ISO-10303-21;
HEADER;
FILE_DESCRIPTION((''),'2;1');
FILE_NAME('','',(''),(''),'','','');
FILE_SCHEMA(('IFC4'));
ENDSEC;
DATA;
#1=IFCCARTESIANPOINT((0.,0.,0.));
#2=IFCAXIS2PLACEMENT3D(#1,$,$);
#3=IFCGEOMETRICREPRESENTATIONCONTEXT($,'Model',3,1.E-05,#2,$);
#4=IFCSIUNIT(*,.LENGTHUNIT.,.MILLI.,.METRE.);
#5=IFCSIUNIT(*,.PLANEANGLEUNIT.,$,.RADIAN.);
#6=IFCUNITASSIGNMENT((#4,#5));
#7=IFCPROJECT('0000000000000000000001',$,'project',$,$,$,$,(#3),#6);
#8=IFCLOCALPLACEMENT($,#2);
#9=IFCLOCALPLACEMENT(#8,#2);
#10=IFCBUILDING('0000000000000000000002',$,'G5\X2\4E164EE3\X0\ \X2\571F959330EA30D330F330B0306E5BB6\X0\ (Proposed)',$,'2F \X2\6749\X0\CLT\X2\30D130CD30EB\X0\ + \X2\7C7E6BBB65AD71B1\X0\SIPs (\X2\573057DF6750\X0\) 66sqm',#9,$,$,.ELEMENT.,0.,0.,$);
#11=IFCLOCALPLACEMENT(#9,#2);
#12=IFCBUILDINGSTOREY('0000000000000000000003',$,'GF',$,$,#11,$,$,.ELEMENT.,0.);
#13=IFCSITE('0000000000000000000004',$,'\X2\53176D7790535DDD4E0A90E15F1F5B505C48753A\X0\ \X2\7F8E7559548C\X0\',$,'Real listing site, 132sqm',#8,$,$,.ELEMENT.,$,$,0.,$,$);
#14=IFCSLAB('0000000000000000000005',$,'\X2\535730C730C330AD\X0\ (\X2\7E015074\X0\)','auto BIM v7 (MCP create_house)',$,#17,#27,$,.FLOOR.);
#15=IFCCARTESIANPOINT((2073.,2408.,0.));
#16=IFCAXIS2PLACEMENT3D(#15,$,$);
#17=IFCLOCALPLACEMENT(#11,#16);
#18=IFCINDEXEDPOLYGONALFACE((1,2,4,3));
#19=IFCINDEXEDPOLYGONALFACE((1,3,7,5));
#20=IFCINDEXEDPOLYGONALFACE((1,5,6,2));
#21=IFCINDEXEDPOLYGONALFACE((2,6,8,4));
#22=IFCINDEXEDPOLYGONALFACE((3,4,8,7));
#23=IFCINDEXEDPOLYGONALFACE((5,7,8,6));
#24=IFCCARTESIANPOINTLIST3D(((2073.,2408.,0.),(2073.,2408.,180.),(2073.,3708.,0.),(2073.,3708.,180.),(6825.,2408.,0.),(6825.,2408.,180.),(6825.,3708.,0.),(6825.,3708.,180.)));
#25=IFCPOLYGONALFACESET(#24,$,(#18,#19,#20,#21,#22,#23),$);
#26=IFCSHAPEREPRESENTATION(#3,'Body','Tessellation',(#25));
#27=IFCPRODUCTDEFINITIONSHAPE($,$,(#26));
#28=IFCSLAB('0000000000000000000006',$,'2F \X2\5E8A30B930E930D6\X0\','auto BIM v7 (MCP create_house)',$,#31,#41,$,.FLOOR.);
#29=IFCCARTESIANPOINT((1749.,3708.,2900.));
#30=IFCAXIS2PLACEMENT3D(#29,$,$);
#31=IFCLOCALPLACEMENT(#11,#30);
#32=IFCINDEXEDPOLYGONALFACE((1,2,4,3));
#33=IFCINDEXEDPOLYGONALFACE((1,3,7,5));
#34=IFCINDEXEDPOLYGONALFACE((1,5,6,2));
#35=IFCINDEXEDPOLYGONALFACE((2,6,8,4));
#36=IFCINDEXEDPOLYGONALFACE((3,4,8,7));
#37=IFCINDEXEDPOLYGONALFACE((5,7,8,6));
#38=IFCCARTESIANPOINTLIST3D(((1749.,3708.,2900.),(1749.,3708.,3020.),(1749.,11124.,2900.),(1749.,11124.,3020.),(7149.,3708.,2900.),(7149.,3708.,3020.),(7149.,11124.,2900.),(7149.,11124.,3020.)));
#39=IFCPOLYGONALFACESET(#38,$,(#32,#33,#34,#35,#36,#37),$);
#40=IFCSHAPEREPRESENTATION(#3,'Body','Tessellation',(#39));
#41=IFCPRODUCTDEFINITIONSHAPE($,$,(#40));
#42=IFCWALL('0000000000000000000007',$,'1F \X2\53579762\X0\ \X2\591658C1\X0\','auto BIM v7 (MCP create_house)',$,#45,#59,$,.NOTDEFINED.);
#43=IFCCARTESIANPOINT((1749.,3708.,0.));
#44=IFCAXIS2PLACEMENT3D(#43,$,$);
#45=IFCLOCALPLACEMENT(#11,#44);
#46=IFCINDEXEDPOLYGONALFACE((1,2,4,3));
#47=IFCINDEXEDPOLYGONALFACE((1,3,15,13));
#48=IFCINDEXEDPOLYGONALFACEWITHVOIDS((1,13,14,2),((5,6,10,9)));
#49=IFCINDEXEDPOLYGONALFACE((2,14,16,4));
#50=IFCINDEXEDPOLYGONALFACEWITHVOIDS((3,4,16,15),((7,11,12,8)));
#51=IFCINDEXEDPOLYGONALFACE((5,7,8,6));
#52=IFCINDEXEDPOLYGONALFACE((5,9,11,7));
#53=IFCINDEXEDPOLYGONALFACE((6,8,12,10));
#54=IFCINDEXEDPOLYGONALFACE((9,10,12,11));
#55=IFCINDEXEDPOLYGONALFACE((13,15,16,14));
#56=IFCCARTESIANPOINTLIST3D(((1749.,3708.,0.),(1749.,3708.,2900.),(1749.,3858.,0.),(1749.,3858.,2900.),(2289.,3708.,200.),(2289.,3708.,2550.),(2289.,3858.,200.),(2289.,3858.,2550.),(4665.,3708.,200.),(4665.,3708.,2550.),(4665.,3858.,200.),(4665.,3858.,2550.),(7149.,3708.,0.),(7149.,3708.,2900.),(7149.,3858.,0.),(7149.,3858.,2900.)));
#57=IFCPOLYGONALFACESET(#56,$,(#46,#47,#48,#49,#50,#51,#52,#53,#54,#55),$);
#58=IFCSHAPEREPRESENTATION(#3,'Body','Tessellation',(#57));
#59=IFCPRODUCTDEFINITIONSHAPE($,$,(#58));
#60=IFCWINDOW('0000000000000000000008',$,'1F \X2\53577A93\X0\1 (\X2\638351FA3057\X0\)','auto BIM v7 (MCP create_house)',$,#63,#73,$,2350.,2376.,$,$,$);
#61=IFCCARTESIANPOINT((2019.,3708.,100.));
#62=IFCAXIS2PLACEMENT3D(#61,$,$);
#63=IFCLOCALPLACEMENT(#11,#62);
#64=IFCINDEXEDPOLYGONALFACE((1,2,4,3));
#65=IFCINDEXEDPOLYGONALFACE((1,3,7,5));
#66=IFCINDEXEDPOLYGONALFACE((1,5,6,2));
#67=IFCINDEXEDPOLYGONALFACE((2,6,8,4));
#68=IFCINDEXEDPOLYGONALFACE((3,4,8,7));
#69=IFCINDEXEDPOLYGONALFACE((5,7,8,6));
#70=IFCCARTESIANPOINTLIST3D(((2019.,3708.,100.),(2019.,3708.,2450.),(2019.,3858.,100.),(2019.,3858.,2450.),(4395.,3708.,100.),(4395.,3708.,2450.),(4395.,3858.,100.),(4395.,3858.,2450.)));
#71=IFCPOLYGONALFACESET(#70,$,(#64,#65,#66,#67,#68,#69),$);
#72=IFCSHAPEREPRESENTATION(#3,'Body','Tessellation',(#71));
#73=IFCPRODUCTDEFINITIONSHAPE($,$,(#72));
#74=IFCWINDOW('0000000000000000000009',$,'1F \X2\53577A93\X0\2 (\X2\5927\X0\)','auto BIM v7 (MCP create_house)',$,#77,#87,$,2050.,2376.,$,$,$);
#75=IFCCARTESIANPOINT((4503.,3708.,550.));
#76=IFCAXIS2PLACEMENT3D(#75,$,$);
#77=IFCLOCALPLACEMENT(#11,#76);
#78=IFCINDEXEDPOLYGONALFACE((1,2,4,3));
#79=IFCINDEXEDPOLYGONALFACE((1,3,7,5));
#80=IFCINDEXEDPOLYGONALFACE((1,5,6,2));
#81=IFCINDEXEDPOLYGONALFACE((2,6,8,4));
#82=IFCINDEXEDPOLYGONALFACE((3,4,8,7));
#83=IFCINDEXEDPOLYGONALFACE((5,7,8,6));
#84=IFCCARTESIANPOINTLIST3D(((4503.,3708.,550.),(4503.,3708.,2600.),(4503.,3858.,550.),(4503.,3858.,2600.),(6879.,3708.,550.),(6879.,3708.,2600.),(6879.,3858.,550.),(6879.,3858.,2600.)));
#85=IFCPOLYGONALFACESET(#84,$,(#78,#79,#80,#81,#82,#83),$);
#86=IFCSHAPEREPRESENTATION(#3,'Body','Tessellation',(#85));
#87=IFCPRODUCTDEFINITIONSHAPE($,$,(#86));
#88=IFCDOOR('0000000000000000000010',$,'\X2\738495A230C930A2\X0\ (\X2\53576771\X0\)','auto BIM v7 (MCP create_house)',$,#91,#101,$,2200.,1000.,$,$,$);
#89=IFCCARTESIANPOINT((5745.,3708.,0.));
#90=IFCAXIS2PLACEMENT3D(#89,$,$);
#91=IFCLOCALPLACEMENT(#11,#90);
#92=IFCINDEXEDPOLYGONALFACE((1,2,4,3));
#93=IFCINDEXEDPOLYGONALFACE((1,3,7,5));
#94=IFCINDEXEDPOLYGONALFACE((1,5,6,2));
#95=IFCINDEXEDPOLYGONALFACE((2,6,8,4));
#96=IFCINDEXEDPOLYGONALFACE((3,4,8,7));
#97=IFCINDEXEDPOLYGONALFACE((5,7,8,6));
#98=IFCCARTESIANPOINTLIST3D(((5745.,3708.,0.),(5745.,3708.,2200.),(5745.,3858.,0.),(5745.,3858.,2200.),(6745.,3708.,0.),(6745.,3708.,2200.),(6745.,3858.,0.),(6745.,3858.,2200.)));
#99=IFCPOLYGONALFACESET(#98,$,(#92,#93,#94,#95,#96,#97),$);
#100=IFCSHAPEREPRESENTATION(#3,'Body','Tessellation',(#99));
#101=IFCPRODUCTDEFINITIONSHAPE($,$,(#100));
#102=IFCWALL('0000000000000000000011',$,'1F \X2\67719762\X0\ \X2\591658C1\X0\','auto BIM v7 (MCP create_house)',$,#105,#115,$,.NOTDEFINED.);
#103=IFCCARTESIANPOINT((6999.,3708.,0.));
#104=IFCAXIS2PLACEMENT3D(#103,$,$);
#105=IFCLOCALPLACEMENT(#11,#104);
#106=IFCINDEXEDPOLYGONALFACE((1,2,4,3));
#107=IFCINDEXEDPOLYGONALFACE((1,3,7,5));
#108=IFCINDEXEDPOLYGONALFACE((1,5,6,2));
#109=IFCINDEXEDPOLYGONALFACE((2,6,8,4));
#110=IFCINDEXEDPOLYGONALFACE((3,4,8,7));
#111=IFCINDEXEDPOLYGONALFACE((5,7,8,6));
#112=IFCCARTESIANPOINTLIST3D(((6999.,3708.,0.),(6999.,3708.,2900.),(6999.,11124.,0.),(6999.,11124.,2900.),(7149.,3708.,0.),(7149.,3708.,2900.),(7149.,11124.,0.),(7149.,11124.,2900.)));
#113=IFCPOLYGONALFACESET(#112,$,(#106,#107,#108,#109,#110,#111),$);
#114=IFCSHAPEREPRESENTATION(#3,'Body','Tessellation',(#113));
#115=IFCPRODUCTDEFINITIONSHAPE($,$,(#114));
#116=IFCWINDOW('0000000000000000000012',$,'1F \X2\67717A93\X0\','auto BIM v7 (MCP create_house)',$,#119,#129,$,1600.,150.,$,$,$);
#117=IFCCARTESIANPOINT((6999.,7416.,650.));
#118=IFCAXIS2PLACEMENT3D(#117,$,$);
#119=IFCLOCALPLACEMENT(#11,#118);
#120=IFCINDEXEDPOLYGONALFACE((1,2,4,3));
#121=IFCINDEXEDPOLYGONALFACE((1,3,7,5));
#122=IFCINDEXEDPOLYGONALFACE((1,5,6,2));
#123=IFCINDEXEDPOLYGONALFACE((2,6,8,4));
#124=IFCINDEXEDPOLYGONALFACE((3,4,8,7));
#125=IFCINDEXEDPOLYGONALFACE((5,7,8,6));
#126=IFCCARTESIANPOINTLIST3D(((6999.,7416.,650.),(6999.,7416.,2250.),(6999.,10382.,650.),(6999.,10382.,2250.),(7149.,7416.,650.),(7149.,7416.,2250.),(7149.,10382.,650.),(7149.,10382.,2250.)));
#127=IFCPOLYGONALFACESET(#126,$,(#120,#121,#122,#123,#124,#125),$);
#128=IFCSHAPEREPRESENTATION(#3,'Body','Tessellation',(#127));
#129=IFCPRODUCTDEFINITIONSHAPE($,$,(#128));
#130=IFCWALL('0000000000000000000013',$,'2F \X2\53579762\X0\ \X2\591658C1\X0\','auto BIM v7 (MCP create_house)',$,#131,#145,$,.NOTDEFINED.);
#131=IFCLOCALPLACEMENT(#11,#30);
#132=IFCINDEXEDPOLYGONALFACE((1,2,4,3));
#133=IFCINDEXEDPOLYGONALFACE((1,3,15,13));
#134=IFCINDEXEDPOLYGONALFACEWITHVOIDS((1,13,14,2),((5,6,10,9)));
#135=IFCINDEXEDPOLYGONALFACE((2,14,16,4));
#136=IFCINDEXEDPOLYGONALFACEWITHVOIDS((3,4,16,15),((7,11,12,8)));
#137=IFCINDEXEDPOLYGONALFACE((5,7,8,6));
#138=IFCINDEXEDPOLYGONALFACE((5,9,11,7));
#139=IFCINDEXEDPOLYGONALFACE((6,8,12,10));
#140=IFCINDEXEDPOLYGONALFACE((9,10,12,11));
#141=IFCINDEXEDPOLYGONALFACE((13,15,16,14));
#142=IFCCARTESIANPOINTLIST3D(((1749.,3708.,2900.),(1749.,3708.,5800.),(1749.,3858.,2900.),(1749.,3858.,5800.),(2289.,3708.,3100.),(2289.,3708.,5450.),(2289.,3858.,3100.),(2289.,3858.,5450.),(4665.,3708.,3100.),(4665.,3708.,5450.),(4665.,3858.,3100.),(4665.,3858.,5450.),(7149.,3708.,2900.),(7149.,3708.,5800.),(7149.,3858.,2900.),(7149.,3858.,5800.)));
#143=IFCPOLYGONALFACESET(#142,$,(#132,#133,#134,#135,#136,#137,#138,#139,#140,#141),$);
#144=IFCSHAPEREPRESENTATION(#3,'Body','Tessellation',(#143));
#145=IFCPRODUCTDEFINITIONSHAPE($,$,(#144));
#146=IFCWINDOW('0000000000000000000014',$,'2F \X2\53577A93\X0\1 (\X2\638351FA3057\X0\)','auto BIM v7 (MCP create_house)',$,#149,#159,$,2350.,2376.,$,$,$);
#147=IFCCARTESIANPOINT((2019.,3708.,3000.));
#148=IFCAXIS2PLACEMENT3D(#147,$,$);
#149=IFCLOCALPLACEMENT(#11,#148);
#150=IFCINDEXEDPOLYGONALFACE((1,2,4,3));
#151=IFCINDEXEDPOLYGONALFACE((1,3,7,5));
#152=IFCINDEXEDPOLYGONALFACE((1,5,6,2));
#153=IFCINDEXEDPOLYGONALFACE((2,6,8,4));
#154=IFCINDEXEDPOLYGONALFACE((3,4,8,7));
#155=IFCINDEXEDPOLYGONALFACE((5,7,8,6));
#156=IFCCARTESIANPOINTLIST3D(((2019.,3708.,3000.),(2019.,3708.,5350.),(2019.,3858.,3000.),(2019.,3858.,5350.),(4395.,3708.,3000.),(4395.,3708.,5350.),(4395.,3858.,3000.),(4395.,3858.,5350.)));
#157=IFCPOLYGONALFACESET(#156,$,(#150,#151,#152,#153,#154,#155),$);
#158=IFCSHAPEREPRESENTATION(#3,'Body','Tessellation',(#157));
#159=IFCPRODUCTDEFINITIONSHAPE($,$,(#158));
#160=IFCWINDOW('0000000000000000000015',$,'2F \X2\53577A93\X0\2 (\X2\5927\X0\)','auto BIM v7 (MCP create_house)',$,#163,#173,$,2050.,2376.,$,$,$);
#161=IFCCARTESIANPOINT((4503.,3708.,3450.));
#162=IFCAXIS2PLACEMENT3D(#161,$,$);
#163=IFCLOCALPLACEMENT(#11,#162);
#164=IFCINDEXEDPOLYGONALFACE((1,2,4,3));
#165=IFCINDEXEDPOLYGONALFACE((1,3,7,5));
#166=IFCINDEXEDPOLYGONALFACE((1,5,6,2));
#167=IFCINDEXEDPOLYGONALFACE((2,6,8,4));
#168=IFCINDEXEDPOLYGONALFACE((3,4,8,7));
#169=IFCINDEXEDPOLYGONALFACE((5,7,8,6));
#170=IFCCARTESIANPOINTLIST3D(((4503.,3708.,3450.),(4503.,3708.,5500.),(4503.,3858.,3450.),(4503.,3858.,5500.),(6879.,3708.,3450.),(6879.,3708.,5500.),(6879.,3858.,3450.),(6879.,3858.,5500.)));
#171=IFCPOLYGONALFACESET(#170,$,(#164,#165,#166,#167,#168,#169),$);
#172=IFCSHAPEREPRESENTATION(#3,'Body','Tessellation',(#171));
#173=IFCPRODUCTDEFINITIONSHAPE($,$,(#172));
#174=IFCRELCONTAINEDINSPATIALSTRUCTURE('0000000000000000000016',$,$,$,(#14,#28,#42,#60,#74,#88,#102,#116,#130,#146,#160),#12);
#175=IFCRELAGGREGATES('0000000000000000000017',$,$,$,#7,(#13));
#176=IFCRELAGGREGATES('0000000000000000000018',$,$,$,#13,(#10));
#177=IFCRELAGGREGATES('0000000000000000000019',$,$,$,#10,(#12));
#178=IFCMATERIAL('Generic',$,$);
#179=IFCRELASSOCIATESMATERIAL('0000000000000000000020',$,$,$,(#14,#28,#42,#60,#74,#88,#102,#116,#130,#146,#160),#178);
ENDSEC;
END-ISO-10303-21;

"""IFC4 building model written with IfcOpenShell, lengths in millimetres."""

from ifc_helpers import new_model, si_unit, frame, frame_2d, origin, place, context, project, spatial, rectangle, extrude, material, element, fill, save


model = new_model("IFC4")

# Units and contexts
model_context = context("Model", 3, precision=1e-05, world=origin())
ifc_project = project(units=[si_unit("LENGTHUNIT", "METRE", prefix="MILLI"), si_unit("PLANEANGLEUNIT", "RADIAN")], contexts=[model_context])

# Site, building, storey
site_placement = place(None, origin())
site = spatial("IfcSite", under=ifc_project, at=site_placement, Name="北海道川上郡弟子屈町 美留和", ObjectType="Real listing site, 132sqm", CompositionType="ELEMENT", RefElevation=0.0)
building_placement = place(site_placement, origin())
building = spatial("IfcBuilding", under=site, at=building_placement, Name="G5世代 土間リビングの家 (Proposed)", ObjectType="2F 杉CLTパネル + 籾殻断熱SIPs (地域材) 66sqm", CompositionType="ELEMENT", ElevationOfRefHeight=0.0, ElevationOfTerrain=0.0)
storey_placement = place(building_placement, origin())
storey = spatial("IfcBuildingStorey", under=building, at=storey_placement, Name="GF", CompositionType="ELEMENT", Elevation=0.0)

# Slabs
ifc_material = material(Name="Generic")
slab_1_placement = place(storey_placement, frame((2073.0, 2408.0, 0.0)))
element("IfcSlab", 1, at=slab_1_placement, inside=storey, material=ifc_material, Name="南デッキ (縁側)", Description="auto BIM v7 (MCP create_house)", PredefinedType="FLOOR", context=model_context, shape_type="SweptSolid", body=[
    extrude(rectangle(XDim=4752.0, YDim=1300.0, at=frame_2d((2376.0, 650.0))), frame((2073.0, 2408.0, 0.0)), (0.0, 0.0, 1.0), 180.0),
])
slab_2_placement = place(storey_placement, frame((1749.0, 3708.0, 2900.0)))
element("IfcSlab", 2, at=slab_2_placement, inside=storey, material=ifc_material, Name="2F 床スラブ", Description="auto BIM v7 (MCP create_house)", PredefinedType="FLOOR", context=model_context, shape_type="SweptSolid", body=[
    extrude(rectangle(XDim=5400.0, YDim=7416.0, at=frame_2d((2700.0, 3708.0))), frame((1749.0, 3708.0, 2900.0)), (0.0, 0.0, 1.0), 120.0),
])

# Wall, openings, windows, door
wall_1_placement = place(storey_placement, frame((1749.0, 3708.0, 0.0)))
wall_1 = element("IfcWall", 3, at=wall_1_placement, inside=storey, material=ifc_material, Name="1F 南面 外壁", Description="auto BIM v7 (MCP create_house)", PredefinedType="NOTDEFINED", context=model_context, shape_type="SweptSolid", body=[
    extrude(rectangle(XDim=5400.0, YDim=150.0, at=frame_2d((2700.0, 75.0))), frame((1749.0, 3708.0, 0.0)), (0.0, 0.0, 1.0), 2900.0),
])
opening_1_placement = place(storey_placement, frame((2019.0, 3708.0, 100.0)))
opening_1 = element("IfcOpeningElement", 4, at=opening_1_placement, cuts=wall_1, PredefinedType="NOTDEFINED", context=model_context, shape_type="SweptSolid", body=[
    extrude(rectangle(XDim=2376.0, YDim=150.0, at=frame_2d((1188.0, 75.0))), frame((2019.0, 3708.0, 100.0)), (0.0, 0.0, 1.0), 2350.0),
])
opening_2_placement = place(storey_placement, frame((4503.0, 3708.0, 550.0)))
opening_2 = element("IfcOpeningElement", 5, at=opening_2_placement, cuts=wall_1, PredefinedType="NOTDEFINED", context=model_context, shape_type="SweptSolid", body=[
    extrude(rectangle(XDim=2376.0, YDim=150.0, at=frame_2d((1188.0, 75.0))), frame((4503.0, 3708.0, 550.0)), (0.0, 0.0, 1.0), 2050.0),
])
opening_3_placement = place(storey_placement, frame((5745.0, 3708.0, 0.0)))
opening_3 = element("IfcOpeningElement", 6, at=opening_3_placement, cuts=wall_1, PredefinedType="NOTDEFINED", context=model_context, shape_type="SweptSolid", body=[
    extrude(rectangle(XDim=1000.0, YDim=150.0, at=frame_2d((500.0, 75.0))), frame((5745.0, 3708.0, 0.0)), (0.0, 0.0, 1.0), 2200.0),
])
window_1_placement = place(storey_placement, frame((2019.0, 3708.0, 100.0)))
window_1 = element("IfcWindow", 7, at=window_1_placement, inside=storey, material=ifc_material, Name="1F 南窓1 (掃出し)", Description="auto BIM v7 (MCP create_house)", OverallHeight=2350.0, OverallWidth=2376.0, context=model_context, shape_type="SweptSolid", body=[
    extrude(rectangle(XDim=2376.0, YDim=150.0, at=frame_2d((1188.0, 75.0))), frame((2019.0, 3708.0, 100.0)), (0.0, 0.0, 1.0), 2350.0),
])
fill(opening_1, window_1)
window_2_placement = place(storey_placement, frame((4503.0, 3708.0, 550.0)))
window_2 = element("IfcWindow", 8, at=window_2_placement, inside=storey, material=ifc_material, Name="1F 南窓2 (大)", Description="auto BIM v7 (MCP create_house)", OverallHeight=2050.0, OverallWidth=2376.0, context=model_context, shape_type="SweptSolid", body=[
    extrude(rectangle(XDim=2376.0, YDim=150.0, at=frame_2d((1188.0, 75.0))), frame((4503.0, 3708.0, 550.0)), (0.0, 0.0, 1.0), 2050.0),
])
fill(opening_2, window_2)
door_placement = place(storey_placement, frame((5745.0, 3708.0, 0.0)))
door = element("IfcDoor", 9, at=door_placement, inside=storey, material=ifc_material, Name="玄関ドア (南東)", Description="auto BIM v7 (MCP create_house)", OverallHeight=2200.0, OverallWidth=1000.0, context=model_context, shape_type="SweptSolid", body=[
    extrude(rectangle(XDim=1000.0, YDim=150.0, at=frame_2d((500.0, 75.0))), frame((5745.0, 3708.0, 0.0)), (0.0, 0.0, 1.0), 2200.0),
])
fill(opening_3, door)

# Wall, opening, window
wall_2_placement = place(storey_placement, frame((6999.0, 3708.0, 0.0)))
wall_2 = element("IfcWall", 10, at=wall_2_placement, inside=storey, material=ifc_material, Name="1F 東面 外壁", Description="auto BIM v7 (MCP create_house)", PredefinedType="NOTDEFINED", context=model_context, shape_type="SweptSolid", body=[
    extrude(rectangle(XDim=150.0, YDim=7416.0, at=frame_2d((75.0, 3708.0))), frame((6999.0, 3708.0, 0.0)), (0.0, 0.0, 1.0), 2900.0),
])
opening_4_placement = place(storey_placement, frame((6999.0, 7416.0, 650.0)))
opening_4 = element("IfcOpeningElement", 11, at=opening_4_placement, cuts=wall_2, PredefinedType="NOTDEFINED", context=model_context, shape_type="SweptSolid", body=[
    extrude(rectangle(XDim=150.0, YDim=2966.0, at=frame_2d((75.0, 1483.0))), frame((6999.0, 7416.0, 650.0)), (0.0, 0.0, 1.0), 1600.0),
])
window_3_placement = place(storey_placement, frame((6999.0, 7416.0, 650.0)))
window_3 = element("IfcWindow", 12, at=window_3_placement, inside=storey, material=ifc_material, Name="1F 東窓", Description="auto BIM v7 (MCP create_house)", OverallHeight=1600.0, OverallWidth=150.0, context=model_context, shape_type="SweptSolid", body=[
    extrude(rectangle(XDim=150.0, YDim=2966.0, at=frame_2d((75.0, 1483.0))), frame((6999.0, 7416.0, 650.0)), (0.0, 0.0, 1.0), 1600.0),
])
fill(opening_4, window_3)

# Wall, openings, windows
wall_3_placement = place(storey_placement, frame((1749.0, 3708.0, 2900.0)))
wall_3 = element("IfcWall", 13, at=wall_3_placement, inside=storey, material=ifc_material, Name="2F 南面 外壁", Description="auto BIM v7 (MCP create_house)", PredefinedType="NOTDEFINED", context=model_context, shape_type="SweptSolid", body=[
    extrude(rectangle(XDim=5400.0, YDim=150.0, at=frame_2d((2700.0, 75.0))), frame((1749.0, 3708.0, 2900.0)), (0.0, 0.0, 1.0), 2900.0),
])
opening_5_placement = place(storey_placement, frame((2019.0, 3708.0, 3000.0)))
opening_5 = element("IfcOpeningElement", 14, at=opening_5_placement, cuts=wall_3, PredefinedType="NOTDEFINED", context=model_context, shape_type="SweptSolid", body=[
    extrude(rectangle(XDim=2376.0, YDim=150.0, at=frame_2d((1188.0, 75.0))), frame((2019.0, 3708.0, 3000.0)), (0.0, 0.0, 1.0), 2350.0),
])
opening_6_placement = place(storey_placement, frame((4503.0, 3708.0, 3450.0)))
opening_6 = element("IfcOpeningElement", 15, at=opening_6_placement, cuts=wall_3, PredefinedType="NOTDEFINED", context=model_context, shape_type="SweptSolid", body=[
    extrude(rectangle(XDim=2376.0, YDim=150.0, at=frame_2d((1188.0, 75.0))), frame((4503.0, 3708.0, 3450.0)), (0.0, 0.0, 1.0), 2050.0),
])
window_4_placement = place(storey_placement, frame((2019.0, 3708.0, 3000.0)))
window_4 = element("IfcWindow", 16, at=window_4_placement, inside=storey, material=ifc_material, Name="2F 南窓1 (掃出し)", Description="auto BIM v7 (MCP create_house)", OverallHeight=2350.0, OverallWidth=2376.0, context=model_context, shape_type="SweptSolid", body=[
    extrude(rectangle(XDim=2376.0, YDim=150.0, at=frame_2d((1188.0, 75.0))), frame((2019.0, 3708.0, 3000.0)), (0.0, 0.0, 1.0), 2350.0),
])
fill(opening_5, window_4)
window_5_placement = place(storey_placement, frame((4503.0, 3708.0, 3450.0)))
window_5 = element("IfcWindow", 17, at=window_5_placement, inside=storey, material=ifc_material, Name="2F 南窓2 (大)", Description="auto BIM v7 (MCP create_house)", OverallHeight=2050.0, OverallWidth=2376.0, context=model_context, shape_type="SweptSolid", body=[
    extrude(rectangle(XDim=2376.0, YDim=150.0, at=frame_2d((1188.0, 75.0))), frame((4503.0, 3708.0, 3450.0)), (0.0, 0.0, 1.0), 2050.0),
])
fill(opening_6, window_5)

save(model, "model.ifc")
